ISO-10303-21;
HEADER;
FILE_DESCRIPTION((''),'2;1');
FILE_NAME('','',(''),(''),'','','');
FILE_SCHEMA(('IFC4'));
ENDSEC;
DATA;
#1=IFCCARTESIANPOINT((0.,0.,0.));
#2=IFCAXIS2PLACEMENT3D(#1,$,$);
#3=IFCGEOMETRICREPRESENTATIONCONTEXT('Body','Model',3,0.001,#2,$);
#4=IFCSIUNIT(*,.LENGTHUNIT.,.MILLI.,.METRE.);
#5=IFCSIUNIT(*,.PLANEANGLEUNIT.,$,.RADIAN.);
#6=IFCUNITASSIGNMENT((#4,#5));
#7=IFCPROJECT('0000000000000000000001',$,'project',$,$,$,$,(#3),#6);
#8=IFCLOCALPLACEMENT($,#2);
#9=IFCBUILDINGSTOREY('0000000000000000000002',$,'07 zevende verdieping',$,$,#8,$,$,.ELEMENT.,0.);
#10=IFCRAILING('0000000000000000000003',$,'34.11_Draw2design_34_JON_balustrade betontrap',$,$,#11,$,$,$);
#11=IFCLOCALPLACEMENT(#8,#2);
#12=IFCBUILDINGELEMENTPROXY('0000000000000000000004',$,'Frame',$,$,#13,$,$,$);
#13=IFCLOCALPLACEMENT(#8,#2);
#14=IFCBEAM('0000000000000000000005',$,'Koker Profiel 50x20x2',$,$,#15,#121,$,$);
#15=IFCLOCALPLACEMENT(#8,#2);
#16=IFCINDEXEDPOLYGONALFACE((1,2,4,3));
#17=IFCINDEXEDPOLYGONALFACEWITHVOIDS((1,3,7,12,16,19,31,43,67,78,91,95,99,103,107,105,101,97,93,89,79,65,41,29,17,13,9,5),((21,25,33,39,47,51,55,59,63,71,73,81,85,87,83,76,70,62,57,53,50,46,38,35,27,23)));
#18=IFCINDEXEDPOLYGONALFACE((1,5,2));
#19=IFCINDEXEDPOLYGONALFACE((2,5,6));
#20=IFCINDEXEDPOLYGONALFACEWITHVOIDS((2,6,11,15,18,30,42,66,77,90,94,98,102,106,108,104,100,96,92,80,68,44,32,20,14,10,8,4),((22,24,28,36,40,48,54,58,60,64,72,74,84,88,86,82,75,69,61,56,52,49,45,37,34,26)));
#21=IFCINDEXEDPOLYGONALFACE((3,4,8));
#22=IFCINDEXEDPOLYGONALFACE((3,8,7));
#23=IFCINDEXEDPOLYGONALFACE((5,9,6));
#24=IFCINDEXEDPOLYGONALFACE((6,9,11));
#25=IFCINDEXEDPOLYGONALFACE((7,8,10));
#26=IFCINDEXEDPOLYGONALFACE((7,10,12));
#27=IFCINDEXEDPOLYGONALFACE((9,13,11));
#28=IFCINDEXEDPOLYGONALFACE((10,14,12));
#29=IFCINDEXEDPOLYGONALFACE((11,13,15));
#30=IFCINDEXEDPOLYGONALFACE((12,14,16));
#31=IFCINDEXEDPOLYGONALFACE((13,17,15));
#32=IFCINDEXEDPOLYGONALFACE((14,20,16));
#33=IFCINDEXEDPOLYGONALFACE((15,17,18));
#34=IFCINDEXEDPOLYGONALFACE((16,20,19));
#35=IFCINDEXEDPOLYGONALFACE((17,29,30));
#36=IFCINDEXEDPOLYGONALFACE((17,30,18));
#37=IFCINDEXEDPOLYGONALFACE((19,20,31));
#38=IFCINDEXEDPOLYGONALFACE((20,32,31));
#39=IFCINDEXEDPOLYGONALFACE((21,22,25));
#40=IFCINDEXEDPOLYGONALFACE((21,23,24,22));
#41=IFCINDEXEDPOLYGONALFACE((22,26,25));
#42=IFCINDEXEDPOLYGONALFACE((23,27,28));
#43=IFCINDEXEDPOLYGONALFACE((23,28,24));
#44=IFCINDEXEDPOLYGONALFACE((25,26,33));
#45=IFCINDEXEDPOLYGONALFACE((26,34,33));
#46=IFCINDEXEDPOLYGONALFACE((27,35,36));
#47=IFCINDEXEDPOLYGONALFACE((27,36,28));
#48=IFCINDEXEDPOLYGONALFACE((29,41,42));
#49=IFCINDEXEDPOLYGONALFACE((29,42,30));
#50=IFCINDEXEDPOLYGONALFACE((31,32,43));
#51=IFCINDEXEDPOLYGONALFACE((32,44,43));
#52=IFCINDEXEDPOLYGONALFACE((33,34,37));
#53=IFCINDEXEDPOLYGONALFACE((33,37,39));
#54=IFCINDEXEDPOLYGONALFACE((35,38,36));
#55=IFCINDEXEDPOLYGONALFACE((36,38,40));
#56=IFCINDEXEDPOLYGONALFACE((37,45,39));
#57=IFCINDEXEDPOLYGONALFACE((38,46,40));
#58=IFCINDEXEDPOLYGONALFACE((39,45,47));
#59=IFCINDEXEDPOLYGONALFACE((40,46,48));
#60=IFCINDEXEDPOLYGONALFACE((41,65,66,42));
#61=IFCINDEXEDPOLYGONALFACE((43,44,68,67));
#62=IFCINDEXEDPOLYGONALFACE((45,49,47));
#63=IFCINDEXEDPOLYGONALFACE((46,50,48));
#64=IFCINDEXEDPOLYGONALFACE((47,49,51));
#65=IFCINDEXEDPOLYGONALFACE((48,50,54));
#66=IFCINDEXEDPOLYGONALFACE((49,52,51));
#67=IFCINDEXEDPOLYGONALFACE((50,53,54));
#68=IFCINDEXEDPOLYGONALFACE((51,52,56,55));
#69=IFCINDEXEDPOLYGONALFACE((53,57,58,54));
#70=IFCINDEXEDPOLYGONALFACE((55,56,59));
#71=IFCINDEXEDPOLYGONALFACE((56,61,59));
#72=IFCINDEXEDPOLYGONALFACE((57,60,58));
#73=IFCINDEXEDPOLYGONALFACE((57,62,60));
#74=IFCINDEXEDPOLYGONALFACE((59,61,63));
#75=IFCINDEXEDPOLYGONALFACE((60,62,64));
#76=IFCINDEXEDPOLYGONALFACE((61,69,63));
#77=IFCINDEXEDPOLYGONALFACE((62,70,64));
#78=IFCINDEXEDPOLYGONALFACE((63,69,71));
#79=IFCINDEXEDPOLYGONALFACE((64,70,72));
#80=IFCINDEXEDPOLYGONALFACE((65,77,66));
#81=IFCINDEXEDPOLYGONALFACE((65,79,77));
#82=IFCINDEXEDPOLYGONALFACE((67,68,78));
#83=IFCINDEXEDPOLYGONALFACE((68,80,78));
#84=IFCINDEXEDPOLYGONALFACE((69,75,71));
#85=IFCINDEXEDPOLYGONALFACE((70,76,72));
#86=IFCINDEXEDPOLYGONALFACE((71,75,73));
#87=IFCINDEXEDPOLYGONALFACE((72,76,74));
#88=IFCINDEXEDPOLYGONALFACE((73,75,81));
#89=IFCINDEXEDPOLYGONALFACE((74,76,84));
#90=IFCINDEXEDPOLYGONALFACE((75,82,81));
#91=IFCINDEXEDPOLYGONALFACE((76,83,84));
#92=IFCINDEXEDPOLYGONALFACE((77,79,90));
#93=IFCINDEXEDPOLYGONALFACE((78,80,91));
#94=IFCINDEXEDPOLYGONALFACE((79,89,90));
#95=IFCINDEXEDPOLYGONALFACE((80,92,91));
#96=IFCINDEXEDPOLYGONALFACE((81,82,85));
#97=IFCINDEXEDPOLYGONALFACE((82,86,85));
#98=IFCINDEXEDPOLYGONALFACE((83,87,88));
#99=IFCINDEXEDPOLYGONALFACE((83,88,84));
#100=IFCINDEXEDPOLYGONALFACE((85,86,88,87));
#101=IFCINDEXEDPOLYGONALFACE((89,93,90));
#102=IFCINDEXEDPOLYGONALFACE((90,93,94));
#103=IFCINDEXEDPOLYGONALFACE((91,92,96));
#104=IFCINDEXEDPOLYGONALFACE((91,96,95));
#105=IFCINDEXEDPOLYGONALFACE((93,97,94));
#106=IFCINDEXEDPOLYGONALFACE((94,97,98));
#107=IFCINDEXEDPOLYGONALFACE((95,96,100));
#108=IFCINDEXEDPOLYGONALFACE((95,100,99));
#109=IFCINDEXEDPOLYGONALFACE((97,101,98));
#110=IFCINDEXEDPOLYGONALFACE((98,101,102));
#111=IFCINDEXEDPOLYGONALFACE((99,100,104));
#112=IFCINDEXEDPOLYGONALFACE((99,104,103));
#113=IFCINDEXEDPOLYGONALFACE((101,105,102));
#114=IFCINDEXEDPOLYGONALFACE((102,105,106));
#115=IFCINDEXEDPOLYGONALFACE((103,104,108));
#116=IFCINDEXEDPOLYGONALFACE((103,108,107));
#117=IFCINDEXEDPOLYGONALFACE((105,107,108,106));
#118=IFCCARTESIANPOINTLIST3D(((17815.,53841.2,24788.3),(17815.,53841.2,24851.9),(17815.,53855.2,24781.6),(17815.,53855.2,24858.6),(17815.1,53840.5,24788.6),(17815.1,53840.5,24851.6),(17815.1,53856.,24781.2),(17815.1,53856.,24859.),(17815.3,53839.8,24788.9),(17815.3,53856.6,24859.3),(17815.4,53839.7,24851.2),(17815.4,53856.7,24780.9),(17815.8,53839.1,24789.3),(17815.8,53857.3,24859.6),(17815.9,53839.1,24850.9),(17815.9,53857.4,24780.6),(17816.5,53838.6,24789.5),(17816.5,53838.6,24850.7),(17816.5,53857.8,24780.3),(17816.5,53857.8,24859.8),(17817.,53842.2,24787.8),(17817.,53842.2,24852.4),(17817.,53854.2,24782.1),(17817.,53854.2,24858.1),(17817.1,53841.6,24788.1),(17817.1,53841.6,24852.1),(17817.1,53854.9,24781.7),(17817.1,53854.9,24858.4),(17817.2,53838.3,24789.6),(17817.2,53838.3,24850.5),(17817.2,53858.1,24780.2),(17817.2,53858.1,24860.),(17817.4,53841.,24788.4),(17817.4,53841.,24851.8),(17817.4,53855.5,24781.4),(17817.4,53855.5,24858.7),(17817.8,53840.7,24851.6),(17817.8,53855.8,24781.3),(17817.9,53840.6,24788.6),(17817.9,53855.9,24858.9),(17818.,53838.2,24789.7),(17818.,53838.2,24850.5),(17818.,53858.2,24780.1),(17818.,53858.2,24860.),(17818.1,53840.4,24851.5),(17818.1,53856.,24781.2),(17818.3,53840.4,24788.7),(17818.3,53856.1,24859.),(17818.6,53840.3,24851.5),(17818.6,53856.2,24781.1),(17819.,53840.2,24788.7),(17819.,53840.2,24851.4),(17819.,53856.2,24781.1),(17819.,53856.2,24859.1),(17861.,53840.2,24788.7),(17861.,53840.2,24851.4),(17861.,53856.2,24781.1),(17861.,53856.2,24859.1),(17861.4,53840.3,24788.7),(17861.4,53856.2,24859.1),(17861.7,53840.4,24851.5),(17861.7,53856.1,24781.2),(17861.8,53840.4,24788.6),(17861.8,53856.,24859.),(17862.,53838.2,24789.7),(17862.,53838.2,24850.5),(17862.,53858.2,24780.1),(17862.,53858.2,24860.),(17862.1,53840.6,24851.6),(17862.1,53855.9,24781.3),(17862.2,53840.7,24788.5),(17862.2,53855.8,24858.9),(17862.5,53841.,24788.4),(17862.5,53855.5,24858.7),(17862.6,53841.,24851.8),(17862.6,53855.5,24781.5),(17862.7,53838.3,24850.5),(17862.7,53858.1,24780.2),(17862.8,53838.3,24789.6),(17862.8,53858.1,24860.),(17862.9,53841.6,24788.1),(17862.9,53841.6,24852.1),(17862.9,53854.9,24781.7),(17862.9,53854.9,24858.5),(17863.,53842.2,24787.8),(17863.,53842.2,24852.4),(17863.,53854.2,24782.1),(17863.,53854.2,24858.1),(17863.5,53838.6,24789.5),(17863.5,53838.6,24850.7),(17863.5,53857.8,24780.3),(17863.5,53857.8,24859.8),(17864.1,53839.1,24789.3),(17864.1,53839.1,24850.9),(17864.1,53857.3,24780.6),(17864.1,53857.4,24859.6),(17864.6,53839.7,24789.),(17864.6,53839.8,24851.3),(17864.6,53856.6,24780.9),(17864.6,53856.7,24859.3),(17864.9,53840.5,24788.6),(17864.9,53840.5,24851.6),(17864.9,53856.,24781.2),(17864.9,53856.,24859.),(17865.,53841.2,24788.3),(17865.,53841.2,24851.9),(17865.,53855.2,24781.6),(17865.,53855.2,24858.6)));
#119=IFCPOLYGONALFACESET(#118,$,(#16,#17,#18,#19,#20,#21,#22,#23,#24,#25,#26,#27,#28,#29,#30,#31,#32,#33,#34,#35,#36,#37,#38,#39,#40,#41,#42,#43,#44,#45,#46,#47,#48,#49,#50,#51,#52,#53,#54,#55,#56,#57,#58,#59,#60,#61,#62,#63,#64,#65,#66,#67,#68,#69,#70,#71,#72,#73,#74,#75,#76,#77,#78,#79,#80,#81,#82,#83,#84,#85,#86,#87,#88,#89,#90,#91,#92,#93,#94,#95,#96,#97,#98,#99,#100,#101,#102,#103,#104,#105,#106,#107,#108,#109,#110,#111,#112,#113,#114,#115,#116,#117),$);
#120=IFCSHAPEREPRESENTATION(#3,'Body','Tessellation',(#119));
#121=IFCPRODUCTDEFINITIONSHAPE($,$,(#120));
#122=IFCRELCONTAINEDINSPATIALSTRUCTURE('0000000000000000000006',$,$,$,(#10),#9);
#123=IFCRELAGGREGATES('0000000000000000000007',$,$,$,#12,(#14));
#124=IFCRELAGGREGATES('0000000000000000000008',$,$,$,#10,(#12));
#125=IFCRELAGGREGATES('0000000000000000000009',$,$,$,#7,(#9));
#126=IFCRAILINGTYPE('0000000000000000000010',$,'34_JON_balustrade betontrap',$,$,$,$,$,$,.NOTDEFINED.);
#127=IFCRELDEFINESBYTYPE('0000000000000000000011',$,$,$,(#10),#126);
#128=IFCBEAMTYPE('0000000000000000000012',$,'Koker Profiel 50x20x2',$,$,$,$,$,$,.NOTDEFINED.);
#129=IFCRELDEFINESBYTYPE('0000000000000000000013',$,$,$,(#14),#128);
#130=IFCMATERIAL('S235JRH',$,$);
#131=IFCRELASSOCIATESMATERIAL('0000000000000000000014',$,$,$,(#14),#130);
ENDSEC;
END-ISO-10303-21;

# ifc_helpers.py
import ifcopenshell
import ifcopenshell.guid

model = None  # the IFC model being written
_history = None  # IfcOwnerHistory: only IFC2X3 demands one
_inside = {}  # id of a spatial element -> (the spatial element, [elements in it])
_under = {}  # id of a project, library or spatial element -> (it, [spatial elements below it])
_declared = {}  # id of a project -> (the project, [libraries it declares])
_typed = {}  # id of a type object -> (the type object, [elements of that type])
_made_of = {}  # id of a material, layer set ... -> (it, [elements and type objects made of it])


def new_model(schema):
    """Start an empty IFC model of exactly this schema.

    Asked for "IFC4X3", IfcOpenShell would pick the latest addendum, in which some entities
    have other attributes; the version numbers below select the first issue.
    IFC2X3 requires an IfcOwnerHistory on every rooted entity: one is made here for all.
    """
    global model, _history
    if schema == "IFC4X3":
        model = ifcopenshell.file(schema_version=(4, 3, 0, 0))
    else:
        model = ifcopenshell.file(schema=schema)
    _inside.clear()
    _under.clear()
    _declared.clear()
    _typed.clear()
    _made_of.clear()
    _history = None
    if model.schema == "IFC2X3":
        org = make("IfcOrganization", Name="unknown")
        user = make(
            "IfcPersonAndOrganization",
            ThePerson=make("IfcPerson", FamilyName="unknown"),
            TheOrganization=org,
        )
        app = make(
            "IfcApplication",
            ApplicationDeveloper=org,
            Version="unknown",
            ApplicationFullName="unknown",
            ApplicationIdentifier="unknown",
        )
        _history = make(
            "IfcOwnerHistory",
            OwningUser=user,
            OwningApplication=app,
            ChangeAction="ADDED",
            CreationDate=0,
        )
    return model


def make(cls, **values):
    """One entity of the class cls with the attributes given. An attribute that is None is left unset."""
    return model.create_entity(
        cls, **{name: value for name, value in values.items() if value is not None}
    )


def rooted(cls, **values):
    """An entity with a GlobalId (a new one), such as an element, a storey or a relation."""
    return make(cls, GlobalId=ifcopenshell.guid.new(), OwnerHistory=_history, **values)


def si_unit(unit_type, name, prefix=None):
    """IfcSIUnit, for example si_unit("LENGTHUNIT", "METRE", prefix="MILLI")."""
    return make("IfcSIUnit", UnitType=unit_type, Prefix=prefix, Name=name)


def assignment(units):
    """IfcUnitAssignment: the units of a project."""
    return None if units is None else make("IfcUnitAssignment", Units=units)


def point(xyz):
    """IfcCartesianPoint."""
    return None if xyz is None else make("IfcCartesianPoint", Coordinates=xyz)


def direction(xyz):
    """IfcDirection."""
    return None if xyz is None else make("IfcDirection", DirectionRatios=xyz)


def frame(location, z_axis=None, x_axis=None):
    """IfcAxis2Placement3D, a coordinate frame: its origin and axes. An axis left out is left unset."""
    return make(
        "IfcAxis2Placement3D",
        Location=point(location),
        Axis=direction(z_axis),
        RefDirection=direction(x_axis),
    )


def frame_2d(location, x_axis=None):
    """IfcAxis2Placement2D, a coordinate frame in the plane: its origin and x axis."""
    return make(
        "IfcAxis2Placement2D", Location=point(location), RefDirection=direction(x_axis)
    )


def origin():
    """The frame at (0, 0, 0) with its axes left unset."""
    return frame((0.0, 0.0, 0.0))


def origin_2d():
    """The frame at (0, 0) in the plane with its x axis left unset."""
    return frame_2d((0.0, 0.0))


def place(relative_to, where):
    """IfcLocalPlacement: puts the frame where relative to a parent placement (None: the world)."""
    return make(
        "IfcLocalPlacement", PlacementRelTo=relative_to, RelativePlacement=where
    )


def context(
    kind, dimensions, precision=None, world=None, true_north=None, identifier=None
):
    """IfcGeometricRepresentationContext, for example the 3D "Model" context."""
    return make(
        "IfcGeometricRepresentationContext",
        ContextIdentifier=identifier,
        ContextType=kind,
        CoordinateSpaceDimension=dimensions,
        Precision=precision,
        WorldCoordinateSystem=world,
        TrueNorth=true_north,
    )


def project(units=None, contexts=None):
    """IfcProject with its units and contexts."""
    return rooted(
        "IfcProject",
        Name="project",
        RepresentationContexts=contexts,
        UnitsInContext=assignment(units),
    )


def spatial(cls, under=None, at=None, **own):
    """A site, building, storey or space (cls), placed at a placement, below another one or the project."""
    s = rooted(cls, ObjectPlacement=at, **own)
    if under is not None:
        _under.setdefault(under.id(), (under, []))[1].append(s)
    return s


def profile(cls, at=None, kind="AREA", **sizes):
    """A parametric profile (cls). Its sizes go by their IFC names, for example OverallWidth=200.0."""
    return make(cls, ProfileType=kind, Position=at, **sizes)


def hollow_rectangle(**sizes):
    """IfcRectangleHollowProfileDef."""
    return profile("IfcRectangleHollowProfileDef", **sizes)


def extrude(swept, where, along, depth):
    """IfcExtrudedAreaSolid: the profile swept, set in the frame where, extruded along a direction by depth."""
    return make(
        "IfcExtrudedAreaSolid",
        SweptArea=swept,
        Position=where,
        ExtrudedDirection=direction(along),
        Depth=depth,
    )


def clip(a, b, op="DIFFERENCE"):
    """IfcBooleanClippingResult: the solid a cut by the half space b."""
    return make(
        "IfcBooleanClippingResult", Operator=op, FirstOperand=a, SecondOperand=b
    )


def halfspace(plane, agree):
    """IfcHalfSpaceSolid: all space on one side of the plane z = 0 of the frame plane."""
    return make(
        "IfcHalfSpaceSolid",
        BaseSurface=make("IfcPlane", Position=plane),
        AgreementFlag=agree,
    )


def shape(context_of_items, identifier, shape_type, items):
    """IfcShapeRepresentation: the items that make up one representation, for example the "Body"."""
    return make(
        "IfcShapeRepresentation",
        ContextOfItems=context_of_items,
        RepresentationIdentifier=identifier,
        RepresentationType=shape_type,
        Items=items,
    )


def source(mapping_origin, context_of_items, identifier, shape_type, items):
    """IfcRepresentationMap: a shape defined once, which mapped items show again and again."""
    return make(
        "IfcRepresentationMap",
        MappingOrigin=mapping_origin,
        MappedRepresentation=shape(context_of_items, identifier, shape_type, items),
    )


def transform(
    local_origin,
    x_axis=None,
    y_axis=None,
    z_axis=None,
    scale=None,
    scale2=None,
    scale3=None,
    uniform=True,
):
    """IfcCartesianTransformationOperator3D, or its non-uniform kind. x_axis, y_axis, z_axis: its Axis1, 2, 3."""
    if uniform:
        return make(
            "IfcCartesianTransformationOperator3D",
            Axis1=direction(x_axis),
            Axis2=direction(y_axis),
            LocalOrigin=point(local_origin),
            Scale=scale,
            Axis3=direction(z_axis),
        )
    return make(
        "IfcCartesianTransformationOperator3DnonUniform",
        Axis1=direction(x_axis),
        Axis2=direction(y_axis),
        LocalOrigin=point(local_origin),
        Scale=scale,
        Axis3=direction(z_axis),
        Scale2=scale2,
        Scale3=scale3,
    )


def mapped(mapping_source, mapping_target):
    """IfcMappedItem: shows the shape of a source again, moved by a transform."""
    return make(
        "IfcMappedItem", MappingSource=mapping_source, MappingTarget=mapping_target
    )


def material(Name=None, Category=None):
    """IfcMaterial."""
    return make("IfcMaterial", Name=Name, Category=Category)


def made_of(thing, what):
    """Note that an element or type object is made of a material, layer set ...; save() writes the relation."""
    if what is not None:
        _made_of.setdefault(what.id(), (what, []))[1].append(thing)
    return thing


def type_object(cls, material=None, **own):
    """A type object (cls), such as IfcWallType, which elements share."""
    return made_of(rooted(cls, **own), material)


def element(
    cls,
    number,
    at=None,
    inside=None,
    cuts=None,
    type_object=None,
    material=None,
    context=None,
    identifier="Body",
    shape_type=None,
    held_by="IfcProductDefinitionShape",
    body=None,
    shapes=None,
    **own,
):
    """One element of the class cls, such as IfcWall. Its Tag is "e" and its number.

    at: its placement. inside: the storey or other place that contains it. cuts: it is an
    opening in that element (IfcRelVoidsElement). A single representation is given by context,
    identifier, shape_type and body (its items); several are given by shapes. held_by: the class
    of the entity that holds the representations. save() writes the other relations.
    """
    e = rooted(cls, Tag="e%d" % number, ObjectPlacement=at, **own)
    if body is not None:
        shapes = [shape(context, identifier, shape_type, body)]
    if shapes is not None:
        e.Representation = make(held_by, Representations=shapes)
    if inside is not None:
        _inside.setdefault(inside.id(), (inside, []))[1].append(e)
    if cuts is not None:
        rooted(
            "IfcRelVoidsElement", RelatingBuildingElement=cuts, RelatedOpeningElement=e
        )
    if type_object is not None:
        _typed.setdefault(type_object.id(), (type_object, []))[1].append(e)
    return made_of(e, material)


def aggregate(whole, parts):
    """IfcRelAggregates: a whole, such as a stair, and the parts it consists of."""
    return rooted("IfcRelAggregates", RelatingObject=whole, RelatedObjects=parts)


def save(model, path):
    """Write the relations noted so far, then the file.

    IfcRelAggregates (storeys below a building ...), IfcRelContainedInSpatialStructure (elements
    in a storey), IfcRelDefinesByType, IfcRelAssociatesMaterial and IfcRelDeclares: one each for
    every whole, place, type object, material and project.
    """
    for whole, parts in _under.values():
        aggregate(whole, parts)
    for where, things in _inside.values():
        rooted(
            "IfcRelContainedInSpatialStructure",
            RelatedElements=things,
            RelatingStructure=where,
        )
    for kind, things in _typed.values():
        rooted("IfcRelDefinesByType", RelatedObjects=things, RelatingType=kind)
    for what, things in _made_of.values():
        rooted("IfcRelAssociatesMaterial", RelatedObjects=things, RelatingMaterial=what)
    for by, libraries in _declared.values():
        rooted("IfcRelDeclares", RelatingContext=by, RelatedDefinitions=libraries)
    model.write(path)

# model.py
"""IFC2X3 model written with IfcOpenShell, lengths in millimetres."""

from ifc_helpers import new_model, si_unit, frame, origin, origin_2d, place, context, project, spatial, hollow_rectangle, extrude, clip, halfspace, source, transform, mapped, material, type_object, element, aggregate, save


model = new_model("IFC2X3")

# Units and contexts
model_context = context("Model", 3, precision=0.001, world=origin(), identifier="Body")
ifc_project = project(units=[si_unit("LENGTHUNIT", "METRE", prefix="MILLI"), si_unit("PLANEANGLEUNIT", "RADIAN")], contexts=[model_context])

# Storey
storey_placement = place(None, origin())
storey = spatial("IfcBuildingStorey", under=ifc_project, at=storey_placement, Name="07 zevende verdieping", CompositionType="ELEMENT", Elevation=0.0)

# Railing, building element proxy, beam
railing_type = type_object("IfcRailingType", Name="34_JON_balustrade betontrap")
railing_placement = place(storey_placement, frame((-2939.5, 7875.7, -24104.2), z_axis=(0.0, 0.0, 1.0), x_axis=(1.0, 0.0, 0.0)))
railing = element("IfcRailing", 1, at=railing_placement, inside=storey, type_object=railing_type, Name="34.11_Draw2design_34_JON_balustrade betontrap")
ifc_material_1 = material(Name="S235JRH")
proxy_1_placement = place(railing_placement, origin())
proxy_1 = element("IfcBuildingElementProxy", 2, at=proxy_1_placement, Name="Frame")
beam_type_1 = type_object("IfcBeamType", Name="Koker Profiel 50x20x2")
shared_shape_1 = source(origin(), model_context, "Body", "Clipping", [
    clip(clip(extrude(hollow_rectangle(XDim=20.0, YDim=50.0, WallThickness=2.0, InnerFilletRadius=2.0, OuterFilletRadius=3.0, at=origin_2d()), origin(), (0.0, 0.0, -1.0), 79.9), halfspace(frame((-10.0, 25.0, -9.6), z_axis=(-0.430948, 0.0, 0.902377), x_axis=(0.902377, 0.0, 0.430948)), False)), halfspace(frame((-10.0, -25.0, -70.3), z_axis=(-0.430948, 0.0, -0.902377), x_axis=(-0.902377, 0.0, 0.430948)), False)),
])
beam_1_placement = place(proxy_1_placement, frame((20779.5, 45972.5, 48964.2), z_axis=(0.0, 0.0, 1.0), x_axis=(0.0, 1.0, 0.0)))
beam_1 = element("IfcBeam", 3, at=beam_1_placement, type_object=beam_type_1, material=ifc_material_1, Name="Koker Profiel 50x20x2", context=model_context, shape_type="MappedRepresentation", body=[
    mapped(shared_shape_1, transform((0.0, 0.0, 0.0), scale=1.0)),
])
aggregate(proxy_1, [beam_1])
aggregate(railing, [proxy_1])

save(model, "model.ifc")
